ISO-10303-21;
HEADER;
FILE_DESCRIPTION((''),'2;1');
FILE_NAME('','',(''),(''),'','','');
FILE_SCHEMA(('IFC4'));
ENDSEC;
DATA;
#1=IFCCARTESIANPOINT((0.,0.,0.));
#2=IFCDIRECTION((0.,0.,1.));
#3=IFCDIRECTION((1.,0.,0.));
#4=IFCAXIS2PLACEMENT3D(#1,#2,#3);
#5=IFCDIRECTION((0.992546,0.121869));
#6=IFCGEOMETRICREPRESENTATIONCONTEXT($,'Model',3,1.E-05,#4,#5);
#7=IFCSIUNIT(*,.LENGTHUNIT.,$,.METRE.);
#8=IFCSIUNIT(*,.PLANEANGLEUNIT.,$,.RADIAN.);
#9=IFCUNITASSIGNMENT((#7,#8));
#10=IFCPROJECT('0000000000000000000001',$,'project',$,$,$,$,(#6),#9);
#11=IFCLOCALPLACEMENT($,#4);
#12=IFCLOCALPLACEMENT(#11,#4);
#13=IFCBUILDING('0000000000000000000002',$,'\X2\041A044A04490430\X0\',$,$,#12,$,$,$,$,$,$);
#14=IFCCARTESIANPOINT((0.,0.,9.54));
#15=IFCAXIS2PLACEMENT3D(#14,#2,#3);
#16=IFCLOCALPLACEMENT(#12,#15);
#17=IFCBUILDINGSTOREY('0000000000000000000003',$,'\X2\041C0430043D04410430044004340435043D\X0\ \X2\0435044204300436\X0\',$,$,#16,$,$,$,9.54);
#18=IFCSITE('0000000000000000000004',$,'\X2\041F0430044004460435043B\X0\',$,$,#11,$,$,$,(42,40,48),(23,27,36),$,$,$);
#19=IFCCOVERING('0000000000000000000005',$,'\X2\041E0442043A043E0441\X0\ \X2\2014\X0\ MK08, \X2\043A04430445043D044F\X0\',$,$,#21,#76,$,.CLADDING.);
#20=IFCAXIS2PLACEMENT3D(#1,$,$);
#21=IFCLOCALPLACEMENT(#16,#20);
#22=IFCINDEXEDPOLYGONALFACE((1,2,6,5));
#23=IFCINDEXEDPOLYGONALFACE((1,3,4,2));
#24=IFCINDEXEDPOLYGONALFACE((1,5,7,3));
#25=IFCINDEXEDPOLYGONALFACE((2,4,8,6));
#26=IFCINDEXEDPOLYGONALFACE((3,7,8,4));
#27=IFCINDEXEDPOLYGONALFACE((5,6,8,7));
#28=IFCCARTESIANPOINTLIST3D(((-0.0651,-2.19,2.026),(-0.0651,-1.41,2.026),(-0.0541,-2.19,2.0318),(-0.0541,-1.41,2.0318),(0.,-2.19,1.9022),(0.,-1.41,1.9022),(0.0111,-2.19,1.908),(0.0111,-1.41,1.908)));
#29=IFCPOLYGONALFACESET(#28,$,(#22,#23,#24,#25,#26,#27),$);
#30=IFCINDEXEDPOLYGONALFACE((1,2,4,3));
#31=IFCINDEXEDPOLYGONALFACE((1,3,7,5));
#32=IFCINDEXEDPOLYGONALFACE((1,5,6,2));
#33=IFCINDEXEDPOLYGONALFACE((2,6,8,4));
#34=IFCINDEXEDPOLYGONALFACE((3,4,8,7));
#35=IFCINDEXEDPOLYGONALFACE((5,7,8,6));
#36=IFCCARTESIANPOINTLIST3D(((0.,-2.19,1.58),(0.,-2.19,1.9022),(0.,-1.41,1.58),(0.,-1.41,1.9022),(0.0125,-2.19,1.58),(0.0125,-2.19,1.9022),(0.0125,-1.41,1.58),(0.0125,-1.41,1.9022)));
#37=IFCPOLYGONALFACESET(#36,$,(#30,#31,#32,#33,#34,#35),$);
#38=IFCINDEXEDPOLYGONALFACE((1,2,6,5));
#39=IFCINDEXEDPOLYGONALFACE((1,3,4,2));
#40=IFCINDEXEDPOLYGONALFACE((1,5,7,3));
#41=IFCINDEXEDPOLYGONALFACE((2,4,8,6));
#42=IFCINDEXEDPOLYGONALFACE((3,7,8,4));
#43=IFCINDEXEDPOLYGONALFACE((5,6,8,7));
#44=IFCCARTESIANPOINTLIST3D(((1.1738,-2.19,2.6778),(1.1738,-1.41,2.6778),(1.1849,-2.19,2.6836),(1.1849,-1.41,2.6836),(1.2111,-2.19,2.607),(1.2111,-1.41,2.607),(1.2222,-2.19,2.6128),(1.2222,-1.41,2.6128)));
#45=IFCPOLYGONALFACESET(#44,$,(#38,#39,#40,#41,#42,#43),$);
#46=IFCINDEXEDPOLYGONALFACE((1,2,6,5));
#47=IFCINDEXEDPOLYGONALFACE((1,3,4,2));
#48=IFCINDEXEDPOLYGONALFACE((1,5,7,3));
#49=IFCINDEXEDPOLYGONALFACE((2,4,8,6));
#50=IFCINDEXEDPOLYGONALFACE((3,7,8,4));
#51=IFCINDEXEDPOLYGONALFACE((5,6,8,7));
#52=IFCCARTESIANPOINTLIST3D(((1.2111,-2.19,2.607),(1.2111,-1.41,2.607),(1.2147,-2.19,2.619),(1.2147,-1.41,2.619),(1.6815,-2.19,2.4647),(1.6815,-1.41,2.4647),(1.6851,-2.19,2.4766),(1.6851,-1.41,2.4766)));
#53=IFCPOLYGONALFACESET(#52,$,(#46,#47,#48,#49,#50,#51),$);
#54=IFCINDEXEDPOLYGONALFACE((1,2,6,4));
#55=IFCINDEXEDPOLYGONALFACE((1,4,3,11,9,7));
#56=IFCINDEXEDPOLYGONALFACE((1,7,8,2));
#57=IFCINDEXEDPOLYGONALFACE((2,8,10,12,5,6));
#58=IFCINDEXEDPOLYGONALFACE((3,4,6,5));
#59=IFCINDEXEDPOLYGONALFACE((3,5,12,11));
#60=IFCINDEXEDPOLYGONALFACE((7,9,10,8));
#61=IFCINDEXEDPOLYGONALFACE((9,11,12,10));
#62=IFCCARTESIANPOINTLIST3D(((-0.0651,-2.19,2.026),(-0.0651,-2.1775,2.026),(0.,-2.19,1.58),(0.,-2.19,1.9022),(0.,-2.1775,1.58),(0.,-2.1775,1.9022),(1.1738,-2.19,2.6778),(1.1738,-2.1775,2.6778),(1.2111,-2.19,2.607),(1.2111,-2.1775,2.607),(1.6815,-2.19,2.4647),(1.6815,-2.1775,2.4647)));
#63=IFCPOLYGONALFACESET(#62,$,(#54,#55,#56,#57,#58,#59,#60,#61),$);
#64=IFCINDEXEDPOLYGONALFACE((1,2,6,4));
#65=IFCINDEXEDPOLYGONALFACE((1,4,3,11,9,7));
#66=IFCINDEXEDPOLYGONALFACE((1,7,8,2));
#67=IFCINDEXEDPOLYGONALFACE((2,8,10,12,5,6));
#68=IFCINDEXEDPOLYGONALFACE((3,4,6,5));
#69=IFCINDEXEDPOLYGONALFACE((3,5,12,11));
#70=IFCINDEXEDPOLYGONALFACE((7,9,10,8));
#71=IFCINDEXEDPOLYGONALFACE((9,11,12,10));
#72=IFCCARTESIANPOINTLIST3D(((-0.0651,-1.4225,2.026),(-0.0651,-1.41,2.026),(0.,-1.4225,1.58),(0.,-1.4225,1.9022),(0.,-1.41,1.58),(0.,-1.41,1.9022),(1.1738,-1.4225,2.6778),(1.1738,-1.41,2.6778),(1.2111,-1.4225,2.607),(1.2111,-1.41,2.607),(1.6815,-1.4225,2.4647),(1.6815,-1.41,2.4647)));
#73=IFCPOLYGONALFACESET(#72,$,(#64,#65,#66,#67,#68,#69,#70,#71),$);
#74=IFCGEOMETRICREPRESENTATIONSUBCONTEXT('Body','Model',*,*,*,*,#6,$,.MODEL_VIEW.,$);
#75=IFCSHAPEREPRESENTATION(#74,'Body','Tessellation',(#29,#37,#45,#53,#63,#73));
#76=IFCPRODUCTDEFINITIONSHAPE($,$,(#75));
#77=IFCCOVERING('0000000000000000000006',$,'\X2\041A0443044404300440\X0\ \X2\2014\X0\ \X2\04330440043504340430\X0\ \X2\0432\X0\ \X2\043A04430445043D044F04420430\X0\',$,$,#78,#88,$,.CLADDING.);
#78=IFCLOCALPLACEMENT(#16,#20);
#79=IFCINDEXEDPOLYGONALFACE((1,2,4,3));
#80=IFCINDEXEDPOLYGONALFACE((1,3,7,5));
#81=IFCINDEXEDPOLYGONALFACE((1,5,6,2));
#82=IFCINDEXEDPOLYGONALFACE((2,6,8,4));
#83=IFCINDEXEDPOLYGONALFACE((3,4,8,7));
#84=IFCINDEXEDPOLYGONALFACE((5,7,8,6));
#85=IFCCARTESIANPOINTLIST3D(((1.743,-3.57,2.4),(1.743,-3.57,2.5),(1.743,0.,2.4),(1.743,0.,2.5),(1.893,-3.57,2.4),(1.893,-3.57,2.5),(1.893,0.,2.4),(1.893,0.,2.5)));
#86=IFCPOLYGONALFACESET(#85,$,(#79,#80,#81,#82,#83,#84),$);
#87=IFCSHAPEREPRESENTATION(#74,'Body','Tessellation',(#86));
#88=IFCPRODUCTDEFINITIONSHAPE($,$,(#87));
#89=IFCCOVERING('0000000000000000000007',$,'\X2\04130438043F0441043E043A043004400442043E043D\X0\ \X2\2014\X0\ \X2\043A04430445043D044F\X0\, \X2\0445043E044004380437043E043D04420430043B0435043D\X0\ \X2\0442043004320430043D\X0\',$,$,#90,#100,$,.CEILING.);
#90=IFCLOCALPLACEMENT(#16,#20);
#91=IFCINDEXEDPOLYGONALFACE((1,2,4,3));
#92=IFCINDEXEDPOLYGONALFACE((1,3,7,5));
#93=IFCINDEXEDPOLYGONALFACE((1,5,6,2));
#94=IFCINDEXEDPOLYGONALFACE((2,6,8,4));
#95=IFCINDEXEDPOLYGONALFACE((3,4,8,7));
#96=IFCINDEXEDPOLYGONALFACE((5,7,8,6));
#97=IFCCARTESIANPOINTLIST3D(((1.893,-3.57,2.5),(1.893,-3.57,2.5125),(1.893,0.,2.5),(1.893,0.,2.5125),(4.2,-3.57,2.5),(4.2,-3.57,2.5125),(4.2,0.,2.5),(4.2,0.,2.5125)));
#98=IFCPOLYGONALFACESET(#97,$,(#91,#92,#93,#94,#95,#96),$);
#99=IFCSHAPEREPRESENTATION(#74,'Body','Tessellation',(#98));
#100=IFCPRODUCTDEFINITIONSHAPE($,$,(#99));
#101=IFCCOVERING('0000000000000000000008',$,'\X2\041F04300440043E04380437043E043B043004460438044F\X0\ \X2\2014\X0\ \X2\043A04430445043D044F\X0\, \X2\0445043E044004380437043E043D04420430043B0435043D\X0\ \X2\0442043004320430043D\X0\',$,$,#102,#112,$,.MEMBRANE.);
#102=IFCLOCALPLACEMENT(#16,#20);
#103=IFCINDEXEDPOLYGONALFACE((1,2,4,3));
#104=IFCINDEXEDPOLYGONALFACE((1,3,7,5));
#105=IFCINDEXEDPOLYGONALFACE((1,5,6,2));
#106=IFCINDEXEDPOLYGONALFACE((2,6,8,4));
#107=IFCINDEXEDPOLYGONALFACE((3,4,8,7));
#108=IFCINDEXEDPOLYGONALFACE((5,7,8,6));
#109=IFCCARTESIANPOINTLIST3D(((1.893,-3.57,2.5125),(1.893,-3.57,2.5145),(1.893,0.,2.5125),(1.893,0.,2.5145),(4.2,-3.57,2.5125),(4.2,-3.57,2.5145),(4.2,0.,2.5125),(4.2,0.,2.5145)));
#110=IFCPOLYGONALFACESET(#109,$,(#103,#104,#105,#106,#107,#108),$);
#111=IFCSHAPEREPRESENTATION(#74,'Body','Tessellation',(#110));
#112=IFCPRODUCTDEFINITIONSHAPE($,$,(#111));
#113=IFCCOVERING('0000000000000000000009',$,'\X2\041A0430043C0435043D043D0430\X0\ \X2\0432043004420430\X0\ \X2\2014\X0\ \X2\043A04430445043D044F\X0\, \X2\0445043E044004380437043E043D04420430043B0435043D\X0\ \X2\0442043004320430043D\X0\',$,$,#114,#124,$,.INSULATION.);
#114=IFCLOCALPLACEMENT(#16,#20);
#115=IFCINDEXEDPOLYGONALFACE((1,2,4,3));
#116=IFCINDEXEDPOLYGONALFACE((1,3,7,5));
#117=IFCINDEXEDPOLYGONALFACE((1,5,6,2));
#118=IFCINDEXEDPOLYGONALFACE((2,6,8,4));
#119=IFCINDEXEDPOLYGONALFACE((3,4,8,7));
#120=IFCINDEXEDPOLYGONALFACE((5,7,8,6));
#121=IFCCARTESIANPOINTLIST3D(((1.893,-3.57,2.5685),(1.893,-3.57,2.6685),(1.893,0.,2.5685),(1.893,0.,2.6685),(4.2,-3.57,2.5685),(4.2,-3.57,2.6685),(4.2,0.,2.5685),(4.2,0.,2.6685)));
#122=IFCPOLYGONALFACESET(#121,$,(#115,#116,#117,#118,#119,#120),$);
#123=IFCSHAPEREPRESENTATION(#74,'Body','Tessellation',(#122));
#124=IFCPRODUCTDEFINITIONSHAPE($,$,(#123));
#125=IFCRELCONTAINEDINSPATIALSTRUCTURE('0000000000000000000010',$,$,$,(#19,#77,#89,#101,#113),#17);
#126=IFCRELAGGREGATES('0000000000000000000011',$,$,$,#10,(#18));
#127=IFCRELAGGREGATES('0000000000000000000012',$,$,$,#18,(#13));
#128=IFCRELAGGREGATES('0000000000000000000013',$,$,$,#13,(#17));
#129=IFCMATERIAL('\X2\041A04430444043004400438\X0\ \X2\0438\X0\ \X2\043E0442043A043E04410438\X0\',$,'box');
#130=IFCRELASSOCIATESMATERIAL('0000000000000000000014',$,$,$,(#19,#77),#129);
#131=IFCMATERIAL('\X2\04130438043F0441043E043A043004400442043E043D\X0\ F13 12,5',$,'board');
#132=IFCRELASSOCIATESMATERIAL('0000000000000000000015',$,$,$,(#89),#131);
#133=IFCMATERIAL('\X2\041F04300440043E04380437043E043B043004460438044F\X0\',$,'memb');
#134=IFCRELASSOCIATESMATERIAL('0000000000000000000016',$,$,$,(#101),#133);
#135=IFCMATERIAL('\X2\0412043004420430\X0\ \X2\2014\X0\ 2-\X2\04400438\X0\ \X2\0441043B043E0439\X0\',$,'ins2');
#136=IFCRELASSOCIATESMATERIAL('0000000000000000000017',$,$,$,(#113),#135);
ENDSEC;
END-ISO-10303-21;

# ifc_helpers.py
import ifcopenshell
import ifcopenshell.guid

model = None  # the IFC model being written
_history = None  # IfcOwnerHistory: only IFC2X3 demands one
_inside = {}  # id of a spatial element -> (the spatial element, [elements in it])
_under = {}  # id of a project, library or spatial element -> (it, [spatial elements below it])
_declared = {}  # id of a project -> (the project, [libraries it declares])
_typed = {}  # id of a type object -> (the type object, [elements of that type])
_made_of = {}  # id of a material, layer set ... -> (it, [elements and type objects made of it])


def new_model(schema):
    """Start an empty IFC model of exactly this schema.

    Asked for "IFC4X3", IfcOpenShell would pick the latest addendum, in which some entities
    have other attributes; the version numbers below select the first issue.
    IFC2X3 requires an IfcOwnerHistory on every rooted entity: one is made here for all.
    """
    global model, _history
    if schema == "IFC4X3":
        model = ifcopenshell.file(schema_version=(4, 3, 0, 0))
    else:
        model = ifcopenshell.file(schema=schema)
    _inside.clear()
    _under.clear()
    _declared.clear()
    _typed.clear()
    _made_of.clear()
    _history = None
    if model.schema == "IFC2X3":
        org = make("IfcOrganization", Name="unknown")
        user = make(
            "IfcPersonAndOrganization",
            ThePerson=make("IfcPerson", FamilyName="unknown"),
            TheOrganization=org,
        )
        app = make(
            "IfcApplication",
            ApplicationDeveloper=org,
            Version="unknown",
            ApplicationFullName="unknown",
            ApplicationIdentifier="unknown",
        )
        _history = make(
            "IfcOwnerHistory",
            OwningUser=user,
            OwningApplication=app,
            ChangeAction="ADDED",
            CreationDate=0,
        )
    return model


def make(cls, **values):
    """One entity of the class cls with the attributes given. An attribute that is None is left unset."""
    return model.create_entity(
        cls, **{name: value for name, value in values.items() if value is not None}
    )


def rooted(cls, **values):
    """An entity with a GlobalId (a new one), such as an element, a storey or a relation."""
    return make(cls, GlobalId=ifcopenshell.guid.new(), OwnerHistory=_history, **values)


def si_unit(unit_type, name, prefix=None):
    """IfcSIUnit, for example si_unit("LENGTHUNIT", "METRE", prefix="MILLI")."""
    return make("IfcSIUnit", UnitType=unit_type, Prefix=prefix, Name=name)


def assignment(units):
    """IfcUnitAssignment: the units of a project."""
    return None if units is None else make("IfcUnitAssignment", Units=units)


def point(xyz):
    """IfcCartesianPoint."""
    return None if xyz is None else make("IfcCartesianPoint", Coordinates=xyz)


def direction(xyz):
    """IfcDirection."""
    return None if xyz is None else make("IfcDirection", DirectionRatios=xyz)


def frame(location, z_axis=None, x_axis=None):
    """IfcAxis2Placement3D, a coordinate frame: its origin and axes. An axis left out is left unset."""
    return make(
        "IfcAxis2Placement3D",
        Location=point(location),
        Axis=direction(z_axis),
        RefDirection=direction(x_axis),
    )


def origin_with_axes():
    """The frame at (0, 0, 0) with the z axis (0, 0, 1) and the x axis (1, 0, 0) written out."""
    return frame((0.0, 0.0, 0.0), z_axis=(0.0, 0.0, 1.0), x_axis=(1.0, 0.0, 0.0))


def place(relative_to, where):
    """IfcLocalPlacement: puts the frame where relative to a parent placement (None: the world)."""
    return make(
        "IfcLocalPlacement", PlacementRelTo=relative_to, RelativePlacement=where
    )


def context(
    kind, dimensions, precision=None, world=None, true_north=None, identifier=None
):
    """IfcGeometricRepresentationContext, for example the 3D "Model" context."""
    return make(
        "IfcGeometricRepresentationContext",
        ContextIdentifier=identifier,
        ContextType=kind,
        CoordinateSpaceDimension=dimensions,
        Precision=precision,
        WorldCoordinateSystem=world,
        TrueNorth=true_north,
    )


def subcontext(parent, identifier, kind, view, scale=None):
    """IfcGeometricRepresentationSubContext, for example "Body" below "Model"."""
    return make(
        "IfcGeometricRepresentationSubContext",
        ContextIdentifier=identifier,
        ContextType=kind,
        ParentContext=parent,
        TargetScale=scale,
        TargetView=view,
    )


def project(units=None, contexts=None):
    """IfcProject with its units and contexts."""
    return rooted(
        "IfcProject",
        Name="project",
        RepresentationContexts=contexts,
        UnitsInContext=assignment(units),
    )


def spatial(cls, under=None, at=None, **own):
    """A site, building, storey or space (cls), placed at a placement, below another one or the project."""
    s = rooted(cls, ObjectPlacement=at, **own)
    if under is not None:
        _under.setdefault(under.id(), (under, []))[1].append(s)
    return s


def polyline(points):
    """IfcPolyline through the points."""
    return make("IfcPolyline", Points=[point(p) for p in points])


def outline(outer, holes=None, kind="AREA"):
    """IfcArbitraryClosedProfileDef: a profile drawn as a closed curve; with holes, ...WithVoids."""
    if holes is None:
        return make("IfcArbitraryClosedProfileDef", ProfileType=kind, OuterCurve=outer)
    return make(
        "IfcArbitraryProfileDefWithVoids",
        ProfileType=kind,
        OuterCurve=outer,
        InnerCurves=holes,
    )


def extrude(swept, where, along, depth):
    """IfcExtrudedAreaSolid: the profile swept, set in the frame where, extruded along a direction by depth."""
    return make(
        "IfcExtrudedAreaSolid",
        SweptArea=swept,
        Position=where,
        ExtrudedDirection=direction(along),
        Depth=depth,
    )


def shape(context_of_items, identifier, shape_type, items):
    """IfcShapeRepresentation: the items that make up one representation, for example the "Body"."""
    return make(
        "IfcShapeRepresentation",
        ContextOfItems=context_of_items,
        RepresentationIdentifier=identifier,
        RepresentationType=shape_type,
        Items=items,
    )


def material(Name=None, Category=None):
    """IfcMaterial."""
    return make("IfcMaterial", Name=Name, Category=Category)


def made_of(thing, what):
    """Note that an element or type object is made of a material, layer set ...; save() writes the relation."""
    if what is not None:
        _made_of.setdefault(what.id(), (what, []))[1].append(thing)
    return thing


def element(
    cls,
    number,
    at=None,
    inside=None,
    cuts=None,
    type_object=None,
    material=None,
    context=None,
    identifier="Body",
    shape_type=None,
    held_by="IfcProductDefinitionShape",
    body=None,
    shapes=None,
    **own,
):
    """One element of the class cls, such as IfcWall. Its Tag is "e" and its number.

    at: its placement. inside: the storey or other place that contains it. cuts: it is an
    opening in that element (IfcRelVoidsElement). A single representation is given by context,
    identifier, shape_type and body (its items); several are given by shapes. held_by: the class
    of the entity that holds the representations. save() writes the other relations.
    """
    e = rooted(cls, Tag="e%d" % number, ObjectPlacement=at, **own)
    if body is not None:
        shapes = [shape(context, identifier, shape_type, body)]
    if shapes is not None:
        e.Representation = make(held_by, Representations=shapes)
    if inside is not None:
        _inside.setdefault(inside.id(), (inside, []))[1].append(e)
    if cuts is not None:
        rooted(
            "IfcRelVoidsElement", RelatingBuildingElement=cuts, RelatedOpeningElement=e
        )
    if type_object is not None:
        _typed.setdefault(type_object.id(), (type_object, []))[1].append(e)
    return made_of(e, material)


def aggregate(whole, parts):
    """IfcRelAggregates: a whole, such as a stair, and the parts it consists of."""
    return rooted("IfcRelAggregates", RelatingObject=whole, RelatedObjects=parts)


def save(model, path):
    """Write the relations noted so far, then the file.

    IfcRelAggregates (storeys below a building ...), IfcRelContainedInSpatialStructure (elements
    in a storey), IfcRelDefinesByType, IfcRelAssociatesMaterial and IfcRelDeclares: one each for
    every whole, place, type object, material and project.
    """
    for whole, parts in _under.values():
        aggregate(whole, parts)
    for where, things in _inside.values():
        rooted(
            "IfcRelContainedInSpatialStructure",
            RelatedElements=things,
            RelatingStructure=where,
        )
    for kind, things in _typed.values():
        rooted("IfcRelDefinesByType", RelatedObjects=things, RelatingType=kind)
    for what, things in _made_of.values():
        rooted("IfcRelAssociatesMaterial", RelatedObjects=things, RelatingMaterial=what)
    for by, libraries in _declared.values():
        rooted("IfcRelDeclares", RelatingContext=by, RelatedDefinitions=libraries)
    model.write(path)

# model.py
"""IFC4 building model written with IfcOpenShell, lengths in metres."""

from ifc_helpers import new_model, si_unit, direction, frame, origin_with_axes, place, context, subcontext, project, spatial, polyline, outline, extrude, material, element, save


model = new_model("IFC4")

# Units and contexts
model_context = context("Model", 3, precision=1e-05, world=origin_with_axes(), true_north=direction((0.992546, 0.121869)))
body_context = subcontext(model_context, "Body", "Model", "MODEL_VIEW")
ifc_project = project(units=[si_unit("LENGTHUNIT", "METRE"), si_unit("PLANEANGLEUNIT", "RADIAN")], contexts=[model_context])

# Site, building, storey
site_placement = place(None, origin_with_axes())
site = spatial("IfcSite", under=ifc_project, at=site_placement, Name="Парцел", RefLatitude=(42, 40, 48), RefLongitude=(23, 27, 36))
building_placement = place(site_placement, origin_with_axes())
building = spatial("IfcBuilding", under=site, at=building_placement, Name="Къща")
storey_placement = place(building_placement, frame((0.0, 0.0, 9.54), z_axis=(0.0, 0.0, 1.0), x_axis=(1.0, 0.0, 0.0)))
storey = spatial("IfcBuildingStorey", under=building, at=storey_placement, Name="Мансарден етаж", Elevation=9.54)

# Coverings
ifc_material_1 = material(Name="Куфари и откоси", Category="box")
covering_1_placement = place(storey_placement, origin_with_axes())
element("IfcCovering", 1, at=covering_1_placement, inside=storey, material=ifc_material_1, Name="Откос — MK08, кухня", PredefinedType="CLADDING", context=body_context, shape_type="SweptSolid", body=[
    extrude(outline(polyline([(-0.0651, -2.026), (0.0, -1.9022), (0.0111, -1.908), (-0.0541, -2.0318), (-0.0651, -2.026)])), frame((0.0, -2.19, 0.0), z_axis=(0.0, 1.0, 0.0), x_axis=(1.0, 0.0, 0.0)), (0.0, 0.0, 1.0), 0.78),
    extrude(outline(polyline([(0.0, -1.9022), (0.0, -1.58), (0.0125, -1.58), (0.0125, -1.9022), (0.0, -1.9022)])), frame((0.0, -2.19, 0.0), z_axis=(0.0, 1.0, 0.0), x_axis=(1.0, 0.0, 0.0)), (0.0, 0.0, 1.0), 0.78),
    extrude(outline(polyline([(1.1738, -2.6778), (1.2111, -2.607), (1.2222, -2.6128), (1.1849, -2.6836), (1.1738, -2.6778)])), frame((0.0, -2.19, 0.0), z_axis=(0.0, 1.0, 0.0), x_axis=(1.0, 0.0, 0.0)), (0.0, 0.0, 1.0), 0.78),
    extrude(outline(polyline([(1.2111, -2.607), (1.6815, -2.4647), (1.6851, -2.4766), (1.2147, -2.619), (1.2111, -2.607)])), frame((0.0, -2.19, 0.0), z_axis=(0.0, 1.0, 0.0), x_axis=(1.0, 0.0, 0.0)), (0.0, 0.0, 1.0), 0.78),
    extrude(outline(polyline([(0.0, -1.58), (0.0, -1.9022), (-0.0651, -2.026), (1.1738, -2.6778), (1.2111, -2.607), (1.6815, -2.4647), (0.0, -1.58)])), frame((0.0, -2.19, 0.0), z_axis=(0.0, 1.0, 0.0), x_axis=(1.0, 0.0, 0.0)), (0.0, 0.0, 1.0), 0.0125),
    extrude(outline(polyline([(0.0, -1.58), (0.0, -1.9022), (-0.0651, -2.026), (1.1738, -2.6778), (1.2111, -2.607), (1.6815, -2.4647), (0.0, -1.58)])), frame((0.0, -1.4225, 0.0), z_axis=(0.0, 1.0, 0.0), x_axis=(1.0, 0.0, 0.0)), (0.0, 0.0, 1.0), 0.0125),
])
covering_2_placement = place(storey_placement, origin_with_axes())
element("IfcCovering", 2, at=covering_2_placement, inside=storey, material=ifc_material_1, Name="Куфар — греда в кухнята", PredefinedType="CLADDING", context=body_context, shape_type="SweptSolid", body=[
    extrude(outline(polyline([(1.743, -2.4), (1.893, -2.4), (1.893, -2.5), (1.743, -2.5), (1.743, -2.4)])), frame((0.0, -3.57, 0.0), z_axis=(0.0, 1.0, 0.0), x_axis=(1.0, 0.0, 0.0)), (0.0, 0.0, 1.0), 3.57),
])
ifc_material_2 = material(Name="Гипсокартон F13 12,5", Category="board")
covering_3_placement = place(storey_placement, origin_with_axes())
element("IfcCovering", 3, at=covering_3_placement, inside=storey, material=ifc_material_2, Name="Гипсокартон — кухня, хоризонтален таван", PredefinedType="CEILING", context=body_context, shape_type="SweptSolid", body=[
    extrude(outline(polyline([(1.893, -2.5), (4.2, -2.5), (4.2, -2.5125), (1.893, -2.5125), (1.893, -2.5)])), frame((0.0, -3.57, 0.0), z_axis=(0.0, 1.0, 0.0), x_axis=(1.0, 0.0, 0.0)), (0.0, 0.0, 1.0), 3.57),
])
ifc_material_3 = material(Name="Пароизолация", Category="memb")
covering_4_placement = place(storey_placement, origin_with_axes())
element("IfcCovering", 4, at=covering_4_placement, inside=storey, material=ifc_material_3, Name="Пароизолация — кухня, хоризонтален таван", PredefinedType="MEMBRANE", context=body_context, shape_type="SweptSolid", body=[
    extrude(outline(polyline([(1.893, -2.5125), (4.2, -2.5125), (4.2, -2.5145), (1.893, -2.5145), (1.893, -2.5125)])), frame((0.0, -3.57, 0.0), z_axis=(0.0, 1.0, 0.0), x_axis=(1.0, 0.0, 0.0)), (0.0, 0.0, 1.0), 3.57),
])
ifc_material_4 = material(Name="Вата — 2-ри слой", Category="ins2")
covering_5_placement = place(storey_placement, origin_with_axes())
element("IfcCovering", 5, at=covering_5_placement, inside=storey, material=ifc_material_4, Name="Каменна вата — кухня, хоризонтален таван", PredefinedType="INSULATION", context=body_context, shape_type="SweptSolid", body=[
    extrude(outline(polyline([(1.893, -2.5685), (4.2, -2.5685), (4.2, -2.6685), (1.893, -2.6685), (1.893, -2.5685)])), frame((0.0, -3.57, 0.0), z_axis=(0.0, 1.0, 0.0), x_axis=(1.0, 0.0, 0.0)), (0.0, 0.0, 1.0), 3.57),
])

save(model, "model.ifc")
